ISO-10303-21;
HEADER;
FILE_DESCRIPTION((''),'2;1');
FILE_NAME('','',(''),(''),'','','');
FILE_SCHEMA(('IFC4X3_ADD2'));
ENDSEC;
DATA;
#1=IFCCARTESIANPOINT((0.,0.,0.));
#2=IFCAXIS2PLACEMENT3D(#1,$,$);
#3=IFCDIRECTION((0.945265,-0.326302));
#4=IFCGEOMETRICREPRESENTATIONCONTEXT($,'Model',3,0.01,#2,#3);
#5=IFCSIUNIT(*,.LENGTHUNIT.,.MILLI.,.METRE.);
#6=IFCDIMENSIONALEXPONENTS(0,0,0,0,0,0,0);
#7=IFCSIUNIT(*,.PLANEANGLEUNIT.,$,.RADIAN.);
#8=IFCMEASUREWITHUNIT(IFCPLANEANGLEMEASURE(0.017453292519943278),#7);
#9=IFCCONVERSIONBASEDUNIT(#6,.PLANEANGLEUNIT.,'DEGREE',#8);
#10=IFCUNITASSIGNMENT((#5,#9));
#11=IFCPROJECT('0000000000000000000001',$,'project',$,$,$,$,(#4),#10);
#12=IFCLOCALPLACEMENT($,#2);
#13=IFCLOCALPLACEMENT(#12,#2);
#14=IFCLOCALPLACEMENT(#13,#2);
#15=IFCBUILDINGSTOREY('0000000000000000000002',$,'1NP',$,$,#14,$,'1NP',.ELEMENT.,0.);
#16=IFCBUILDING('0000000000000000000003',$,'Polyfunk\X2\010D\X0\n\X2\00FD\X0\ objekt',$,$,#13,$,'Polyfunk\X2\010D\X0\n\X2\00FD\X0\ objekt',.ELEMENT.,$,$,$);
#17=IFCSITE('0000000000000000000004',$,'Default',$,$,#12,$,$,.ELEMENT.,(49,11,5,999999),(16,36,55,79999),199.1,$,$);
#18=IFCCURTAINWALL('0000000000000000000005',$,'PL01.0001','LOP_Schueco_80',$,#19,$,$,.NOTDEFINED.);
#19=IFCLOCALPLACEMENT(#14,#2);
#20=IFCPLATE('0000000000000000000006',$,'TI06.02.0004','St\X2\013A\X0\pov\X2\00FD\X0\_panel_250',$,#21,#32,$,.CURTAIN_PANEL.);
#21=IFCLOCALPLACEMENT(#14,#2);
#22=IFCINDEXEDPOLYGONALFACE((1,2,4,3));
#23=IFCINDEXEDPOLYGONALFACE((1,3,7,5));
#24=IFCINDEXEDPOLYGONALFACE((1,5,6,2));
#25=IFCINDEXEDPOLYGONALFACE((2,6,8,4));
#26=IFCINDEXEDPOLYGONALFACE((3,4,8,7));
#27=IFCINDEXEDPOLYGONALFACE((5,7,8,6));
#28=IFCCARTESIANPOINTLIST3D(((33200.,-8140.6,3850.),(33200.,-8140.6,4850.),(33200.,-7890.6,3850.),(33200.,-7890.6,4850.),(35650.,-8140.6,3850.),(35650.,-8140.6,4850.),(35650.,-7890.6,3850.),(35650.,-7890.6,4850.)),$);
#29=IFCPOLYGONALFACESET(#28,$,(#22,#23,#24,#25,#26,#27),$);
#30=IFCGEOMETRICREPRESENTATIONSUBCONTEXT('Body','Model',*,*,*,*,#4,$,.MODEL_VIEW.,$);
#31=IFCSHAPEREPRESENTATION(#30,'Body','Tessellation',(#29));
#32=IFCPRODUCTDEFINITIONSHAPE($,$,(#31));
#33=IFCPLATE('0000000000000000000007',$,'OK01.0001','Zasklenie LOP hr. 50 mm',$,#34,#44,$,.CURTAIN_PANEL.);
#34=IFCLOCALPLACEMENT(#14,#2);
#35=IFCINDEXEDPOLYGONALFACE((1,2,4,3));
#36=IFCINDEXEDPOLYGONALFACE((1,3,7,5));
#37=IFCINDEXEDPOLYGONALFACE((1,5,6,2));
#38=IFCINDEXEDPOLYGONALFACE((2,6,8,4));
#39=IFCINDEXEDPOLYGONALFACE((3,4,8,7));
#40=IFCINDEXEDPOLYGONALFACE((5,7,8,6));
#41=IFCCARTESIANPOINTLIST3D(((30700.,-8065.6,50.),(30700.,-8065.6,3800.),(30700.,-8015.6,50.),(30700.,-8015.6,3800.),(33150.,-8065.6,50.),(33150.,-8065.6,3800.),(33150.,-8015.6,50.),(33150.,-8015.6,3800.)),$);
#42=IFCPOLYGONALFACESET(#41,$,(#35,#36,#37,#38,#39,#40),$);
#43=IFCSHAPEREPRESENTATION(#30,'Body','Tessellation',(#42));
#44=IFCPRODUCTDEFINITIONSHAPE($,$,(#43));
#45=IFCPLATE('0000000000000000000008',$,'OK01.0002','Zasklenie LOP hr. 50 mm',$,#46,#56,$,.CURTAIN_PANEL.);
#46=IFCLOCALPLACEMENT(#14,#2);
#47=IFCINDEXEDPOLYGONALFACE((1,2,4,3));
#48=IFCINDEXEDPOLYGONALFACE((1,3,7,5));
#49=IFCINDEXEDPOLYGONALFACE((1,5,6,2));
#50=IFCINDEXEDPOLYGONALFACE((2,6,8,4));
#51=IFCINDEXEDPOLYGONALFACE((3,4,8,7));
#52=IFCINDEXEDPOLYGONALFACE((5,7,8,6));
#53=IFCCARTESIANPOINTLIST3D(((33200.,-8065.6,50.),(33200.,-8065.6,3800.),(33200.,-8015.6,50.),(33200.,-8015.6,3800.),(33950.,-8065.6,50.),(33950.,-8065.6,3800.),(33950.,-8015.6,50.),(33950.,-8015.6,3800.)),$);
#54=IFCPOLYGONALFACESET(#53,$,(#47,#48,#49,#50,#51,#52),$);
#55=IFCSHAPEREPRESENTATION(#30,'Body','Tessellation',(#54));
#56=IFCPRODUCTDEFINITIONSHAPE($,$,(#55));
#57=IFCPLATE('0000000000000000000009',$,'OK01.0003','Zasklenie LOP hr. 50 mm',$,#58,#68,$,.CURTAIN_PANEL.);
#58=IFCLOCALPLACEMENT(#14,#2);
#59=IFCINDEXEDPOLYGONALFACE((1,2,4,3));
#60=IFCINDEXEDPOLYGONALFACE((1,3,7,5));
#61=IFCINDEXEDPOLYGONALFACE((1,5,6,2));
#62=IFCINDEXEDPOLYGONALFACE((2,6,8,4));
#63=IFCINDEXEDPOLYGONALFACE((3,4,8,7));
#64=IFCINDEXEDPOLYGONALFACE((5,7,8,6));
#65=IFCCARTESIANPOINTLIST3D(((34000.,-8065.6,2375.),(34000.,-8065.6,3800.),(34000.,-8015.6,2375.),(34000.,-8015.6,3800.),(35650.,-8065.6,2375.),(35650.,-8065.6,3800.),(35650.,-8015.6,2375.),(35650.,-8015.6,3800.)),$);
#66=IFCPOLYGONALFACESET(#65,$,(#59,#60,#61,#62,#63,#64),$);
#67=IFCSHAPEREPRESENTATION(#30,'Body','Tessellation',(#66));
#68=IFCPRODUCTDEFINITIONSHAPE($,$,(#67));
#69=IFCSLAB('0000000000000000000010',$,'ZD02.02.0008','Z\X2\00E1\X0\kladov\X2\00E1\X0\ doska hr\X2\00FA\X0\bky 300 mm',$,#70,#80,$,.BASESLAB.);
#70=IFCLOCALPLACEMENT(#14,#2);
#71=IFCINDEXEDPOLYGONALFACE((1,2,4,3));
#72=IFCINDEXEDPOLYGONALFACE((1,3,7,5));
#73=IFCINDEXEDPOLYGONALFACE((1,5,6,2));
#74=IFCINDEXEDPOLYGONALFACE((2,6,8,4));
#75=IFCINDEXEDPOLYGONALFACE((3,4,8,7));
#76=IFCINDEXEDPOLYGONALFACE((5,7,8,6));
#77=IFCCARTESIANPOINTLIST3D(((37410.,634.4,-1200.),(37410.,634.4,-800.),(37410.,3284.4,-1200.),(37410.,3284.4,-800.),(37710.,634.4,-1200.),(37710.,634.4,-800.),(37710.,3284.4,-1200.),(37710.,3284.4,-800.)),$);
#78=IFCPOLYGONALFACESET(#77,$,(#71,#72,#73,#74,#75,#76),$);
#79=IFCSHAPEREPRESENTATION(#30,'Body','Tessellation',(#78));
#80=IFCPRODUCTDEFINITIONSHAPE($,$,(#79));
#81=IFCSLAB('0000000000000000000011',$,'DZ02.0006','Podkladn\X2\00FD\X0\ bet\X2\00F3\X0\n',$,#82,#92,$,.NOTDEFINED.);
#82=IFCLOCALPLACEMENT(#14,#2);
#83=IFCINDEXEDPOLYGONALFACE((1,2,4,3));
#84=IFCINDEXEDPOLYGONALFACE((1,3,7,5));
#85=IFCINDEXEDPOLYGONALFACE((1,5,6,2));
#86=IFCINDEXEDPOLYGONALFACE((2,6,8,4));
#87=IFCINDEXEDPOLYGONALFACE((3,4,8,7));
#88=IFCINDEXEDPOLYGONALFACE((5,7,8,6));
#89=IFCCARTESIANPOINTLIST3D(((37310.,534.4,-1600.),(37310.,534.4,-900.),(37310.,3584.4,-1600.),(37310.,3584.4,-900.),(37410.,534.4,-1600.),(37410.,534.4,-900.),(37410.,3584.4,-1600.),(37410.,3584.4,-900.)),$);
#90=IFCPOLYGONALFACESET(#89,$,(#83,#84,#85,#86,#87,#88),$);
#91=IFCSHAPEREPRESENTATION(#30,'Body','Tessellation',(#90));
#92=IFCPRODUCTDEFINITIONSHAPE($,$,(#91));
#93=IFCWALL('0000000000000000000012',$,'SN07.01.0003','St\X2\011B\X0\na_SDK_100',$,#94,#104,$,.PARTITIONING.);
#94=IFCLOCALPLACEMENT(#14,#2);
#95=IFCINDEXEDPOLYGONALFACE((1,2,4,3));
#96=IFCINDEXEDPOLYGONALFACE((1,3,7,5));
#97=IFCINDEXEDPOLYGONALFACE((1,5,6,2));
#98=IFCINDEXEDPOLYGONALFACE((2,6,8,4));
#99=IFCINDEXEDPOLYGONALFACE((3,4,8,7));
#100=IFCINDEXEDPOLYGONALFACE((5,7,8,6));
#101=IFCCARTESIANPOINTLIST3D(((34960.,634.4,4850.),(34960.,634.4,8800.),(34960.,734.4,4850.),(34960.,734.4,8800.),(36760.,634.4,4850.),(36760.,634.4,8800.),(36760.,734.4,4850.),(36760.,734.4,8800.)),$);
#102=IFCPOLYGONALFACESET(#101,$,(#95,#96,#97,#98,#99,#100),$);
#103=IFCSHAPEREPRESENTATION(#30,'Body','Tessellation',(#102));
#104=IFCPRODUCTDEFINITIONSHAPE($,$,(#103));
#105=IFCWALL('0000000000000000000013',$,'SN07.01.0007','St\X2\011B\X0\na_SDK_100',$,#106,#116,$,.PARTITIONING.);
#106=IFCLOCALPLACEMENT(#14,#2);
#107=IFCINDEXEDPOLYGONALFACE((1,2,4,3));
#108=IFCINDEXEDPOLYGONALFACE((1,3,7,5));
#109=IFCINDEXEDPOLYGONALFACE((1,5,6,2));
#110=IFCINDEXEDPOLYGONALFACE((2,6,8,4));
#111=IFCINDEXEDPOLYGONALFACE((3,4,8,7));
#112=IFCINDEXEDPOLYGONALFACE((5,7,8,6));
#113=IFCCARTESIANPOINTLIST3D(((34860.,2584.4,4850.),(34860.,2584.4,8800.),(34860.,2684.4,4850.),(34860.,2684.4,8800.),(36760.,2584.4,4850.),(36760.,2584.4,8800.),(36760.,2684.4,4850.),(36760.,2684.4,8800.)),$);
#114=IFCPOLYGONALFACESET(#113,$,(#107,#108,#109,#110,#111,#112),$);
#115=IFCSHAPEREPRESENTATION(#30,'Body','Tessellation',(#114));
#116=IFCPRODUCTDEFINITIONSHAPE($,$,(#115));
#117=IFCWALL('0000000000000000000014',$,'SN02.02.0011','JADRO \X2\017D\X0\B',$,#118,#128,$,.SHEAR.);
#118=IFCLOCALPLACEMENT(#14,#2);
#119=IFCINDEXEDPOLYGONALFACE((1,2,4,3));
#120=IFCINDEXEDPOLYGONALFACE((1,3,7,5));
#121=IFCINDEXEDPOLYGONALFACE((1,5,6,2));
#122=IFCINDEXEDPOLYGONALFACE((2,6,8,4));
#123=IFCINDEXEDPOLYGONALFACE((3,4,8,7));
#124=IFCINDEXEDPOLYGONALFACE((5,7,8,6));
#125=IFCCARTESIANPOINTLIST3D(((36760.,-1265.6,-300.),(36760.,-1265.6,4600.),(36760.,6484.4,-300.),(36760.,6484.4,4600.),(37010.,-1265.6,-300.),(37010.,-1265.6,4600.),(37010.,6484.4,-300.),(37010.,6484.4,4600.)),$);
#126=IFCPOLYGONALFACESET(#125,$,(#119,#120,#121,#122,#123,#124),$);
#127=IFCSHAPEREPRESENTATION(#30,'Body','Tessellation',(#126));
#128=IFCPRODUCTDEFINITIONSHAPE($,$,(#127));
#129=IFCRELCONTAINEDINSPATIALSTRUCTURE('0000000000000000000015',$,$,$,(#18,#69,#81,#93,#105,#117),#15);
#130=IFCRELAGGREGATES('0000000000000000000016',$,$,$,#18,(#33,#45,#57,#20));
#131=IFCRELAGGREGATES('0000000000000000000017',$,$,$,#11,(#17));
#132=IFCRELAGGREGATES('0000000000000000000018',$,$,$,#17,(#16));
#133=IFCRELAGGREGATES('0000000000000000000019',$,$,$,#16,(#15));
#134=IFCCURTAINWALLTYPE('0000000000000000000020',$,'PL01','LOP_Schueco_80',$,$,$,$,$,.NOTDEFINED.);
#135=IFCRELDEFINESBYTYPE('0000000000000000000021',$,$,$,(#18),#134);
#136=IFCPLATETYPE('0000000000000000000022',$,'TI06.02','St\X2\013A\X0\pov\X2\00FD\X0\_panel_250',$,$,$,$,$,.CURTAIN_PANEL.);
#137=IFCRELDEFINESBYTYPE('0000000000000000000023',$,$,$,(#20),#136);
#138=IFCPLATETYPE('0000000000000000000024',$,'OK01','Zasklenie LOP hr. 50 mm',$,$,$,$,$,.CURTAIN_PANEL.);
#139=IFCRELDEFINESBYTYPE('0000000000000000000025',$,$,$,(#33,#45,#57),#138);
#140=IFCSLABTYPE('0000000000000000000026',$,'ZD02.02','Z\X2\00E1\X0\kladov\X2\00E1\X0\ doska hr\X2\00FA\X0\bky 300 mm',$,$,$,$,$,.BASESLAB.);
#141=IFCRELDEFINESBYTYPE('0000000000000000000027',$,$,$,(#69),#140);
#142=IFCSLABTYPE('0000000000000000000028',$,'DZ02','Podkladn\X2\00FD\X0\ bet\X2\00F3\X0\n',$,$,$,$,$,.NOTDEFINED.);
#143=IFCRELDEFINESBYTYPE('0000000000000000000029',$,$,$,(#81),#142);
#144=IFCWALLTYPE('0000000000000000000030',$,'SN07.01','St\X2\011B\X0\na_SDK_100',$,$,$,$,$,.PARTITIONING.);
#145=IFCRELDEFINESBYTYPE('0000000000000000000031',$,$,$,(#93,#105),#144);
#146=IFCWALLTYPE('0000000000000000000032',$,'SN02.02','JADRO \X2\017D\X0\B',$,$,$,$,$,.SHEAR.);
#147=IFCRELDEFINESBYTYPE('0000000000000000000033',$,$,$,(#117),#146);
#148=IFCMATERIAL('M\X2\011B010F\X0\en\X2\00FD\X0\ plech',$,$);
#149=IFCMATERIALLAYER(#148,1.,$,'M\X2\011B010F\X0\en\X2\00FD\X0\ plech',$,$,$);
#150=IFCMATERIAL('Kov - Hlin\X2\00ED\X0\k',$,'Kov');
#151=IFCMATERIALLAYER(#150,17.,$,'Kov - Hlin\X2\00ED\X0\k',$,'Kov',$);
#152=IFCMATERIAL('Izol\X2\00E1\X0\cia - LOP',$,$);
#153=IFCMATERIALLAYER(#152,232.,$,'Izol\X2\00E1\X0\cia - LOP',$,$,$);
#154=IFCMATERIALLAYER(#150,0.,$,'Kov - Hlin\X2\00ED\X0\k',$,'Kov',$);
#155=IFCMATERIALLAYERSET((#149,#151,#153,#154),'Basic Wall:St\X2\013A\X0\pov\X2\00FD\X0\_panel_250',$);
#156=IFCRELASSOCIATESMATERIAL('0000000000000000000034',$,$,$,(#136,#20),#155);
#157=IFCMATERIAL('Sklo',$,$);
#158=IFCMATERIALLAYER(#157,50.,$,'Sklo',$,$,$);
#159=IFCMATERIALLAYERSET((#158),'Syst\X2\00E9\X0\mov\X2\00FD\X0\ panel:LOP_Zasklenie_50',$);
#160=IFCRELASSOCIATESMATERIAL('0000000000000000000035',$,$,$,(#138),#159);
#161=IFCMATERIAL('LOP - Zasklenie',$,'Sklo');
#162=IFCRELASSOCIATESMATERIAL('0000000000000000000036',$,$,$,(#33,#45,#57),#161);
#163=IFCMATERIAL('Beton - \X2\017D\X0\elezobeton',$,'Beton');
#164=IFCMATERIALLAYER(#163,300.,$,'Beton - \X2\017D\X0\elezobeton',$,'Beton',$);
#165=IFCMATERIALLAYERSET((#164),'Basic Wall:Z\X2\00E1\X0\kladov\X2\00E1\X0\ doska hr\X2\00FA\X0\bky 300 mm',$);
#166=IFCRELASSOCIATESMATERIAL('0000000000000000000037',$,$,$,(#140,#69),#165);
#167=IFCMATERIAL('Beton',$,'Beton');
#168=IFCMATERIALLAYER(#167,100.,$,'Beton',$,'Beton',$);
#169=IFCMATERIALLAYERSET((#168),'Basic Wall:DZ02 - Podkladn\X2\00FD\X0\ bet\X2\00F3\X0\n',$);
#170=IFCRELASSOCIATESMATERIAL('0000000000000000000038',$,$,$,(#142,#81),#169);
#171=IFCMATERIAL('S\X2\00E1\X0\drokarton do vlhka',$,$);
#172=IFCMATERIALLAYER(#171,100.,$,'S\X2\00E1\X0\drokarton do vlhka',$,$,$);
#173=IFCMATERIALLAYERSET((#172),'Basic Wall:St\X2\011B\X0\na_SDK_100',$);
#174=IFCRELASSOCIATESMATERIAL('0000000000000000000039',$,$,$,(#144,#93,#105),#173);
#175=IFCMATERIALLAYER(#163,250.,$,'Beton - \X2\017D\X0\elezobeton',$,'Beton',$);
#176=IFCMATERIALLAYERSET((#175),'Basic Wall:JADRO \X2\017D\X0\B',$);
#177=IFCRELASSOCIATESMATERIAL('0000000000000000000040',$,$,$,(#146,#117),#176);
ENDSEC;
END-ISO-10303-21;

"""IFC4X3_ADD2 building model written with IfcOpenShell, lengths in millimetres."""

from ifc_helpers import new_model, entity, si_unit, converted_unit, direction, frame, frame_2d, origin, place, context, subcontext, project, spatial, polyline, rectangle, extrude, clip, bounded_halfspace, source, transform, mapped, material, layer, layer_set, layer_usage, type_object, type_shapes, element, aggregate, save


model = new_model("IFC4X3_ADD2")

# Units and contexts
model_context = context("Model", 3, precision=0.01, world=origin(), true_north=direction((0.945265, -0.326302)))
body_context = subcontext(model_context, "Body", "Model", "MODEL_VIEW")
ifc_project = project(units=[si_unit("LENGTHUNIT", "METRE", prefix="MILLI"), converted_unit("PLANEANGLEUNIT", "DEGREE", entity("IfcPlaneAngleMeasure", 0.017453292519943278), si_unit("PLANEANGLEUNIT", "RADIAN"), dimensions=[0, 0, 0, 0, 0, 0, 0])], contexts=[model_context])

# Site, building, storey
site_placement = place(None, origin())
site = spatial("IfcSite", under=ifc_project, at=site_placement, Name="Default", CompositionType="ELEMENT", RefLatitude=(49, 11, 5, 999999), RefLongitude=(16, 36, 55, 79999), RefElevation=199.1)
building_placement = place(site_placement, origin())
building = spatial("IfcBuilding", under=site, at=building_placement, Name="Polyfunkčný objekt", LongName="Polyfunkčný objekt", CompositionType="ELEMENT")
storey_placement = place(building_placement, origin())
storey = spatial("IfcBuildingStorey", under=building, at=storey_placement, Name="1NP", LongName="1NP", CompositionType="ELEMENT", Elevation=0.0)

# Curtain wall, plates
curtain_wall_type = type_object("IfcCurtainWallType", Name="PL01", Description="LOP_Schueco_80", PredefinedType="NOTDEFINED")
curtain_wall_placement = place(storey_placement, origin())
curtain_wall = element("IfcCurtainWall", 1, at=curtain_wall_placement, inside=storey, type_object=curtain_wall_type, Name="PL01.0001", Description="LOP_Schueco_80", PredefinedType="NOTDEFINED")
ifc_material_1 = material(Name="Měďený plech")
ifc_layer_1 = layer(ifc_material_1, 1.0, Name="Měďený plech")
ifc_material_2 = material(Name="Kov - Hliník", Category="Kov")
ifc_layer_2 = layer(ifc_material_2, 17.0, Name="Kov - Hliník", Category="Kov")
ifc_material_3 = material(Name="Izolácia - LOP")
ifc_layer_3 = layer(ifc_material_3, 232.0, Name="Izolácia - LOP")
ifc_layer_4 = layer(ifc_material_2, 0.0, Name="Kov - Hliník", Category="Kov")
ifc_layer_set_1 = layer_set([ifc_layer_1, ifc_layer_2, ifc_layer_3, ifc_layer_4], Name="Basic Wall:Stĺpový_panel_250")
ifc_layer_usage_1 = layer_usage(ifc_layer_set_1, "AXIS2", "POSITIVE", -125.0)
plate_type_1 = type_object("IfcPlateType", Name="TI06.02", Description="Stĺpový_panel_250", PredefinedType="CURTAIN_PANEL", material=ifc_layer_set_1)
plate_1_placement = place(storey_placement, frame((33200.0, -8015.6, 3850.0)))
plate_1 = element("IfcPlate", 2, at=plate_1_placement, type_object=plate_type_1, material=ifc_layer_usage_1, Name="TI06.02.0004", Description="Stĺpový_panel_250", PredefinedType="CURTAIN_PANEL", context=body_context, shape_type="SweptSolid", body=[
    extrude(rectangle(XDim=250.0, YDim=2450.0, at=frame_2d((0.0, 0.0), x_axis=(1.0, 0.0))), frame((1225.0, 0.0, 0.0), z_axis=(0.0, 0.0, 1.0), x_axis=(0.0, 1.0, 0.0)), (0.0, 0.0, 1.0), 1000.0),
])
ifc_material_4 = material(Name="LOP - Zasklenie", Category="Sklo")
ifc_material_5 = material(Name="Sklo")
ifc_layer_5 = layer(ifc_material_5, 50.0, Name="Sklo")
ifc_layer_set_2 = layer_set([ifc_layer_5], Name="Systémový panel:LOP_Zasklenie_50")
plate_type_2 = type_object("IfcPlateType", Name="OK01", Description="Zasklenie LOP hr. 50 mm", PredefinedType="CURTAIN_PANEL", material=ifc_layer_set_2)
shared_shape_1 = source(origin(), body_context, "Body", "SweptSolid", [
    extrude(rectangle(XDim=3750.0, YDim=2450.0, at=frame_2d((-331.2, 0.0), x_axis=(1.0, 0.0))), frame((0.0, -50.0, 2206.2), z_axis=(0.0, 1.0, 0.0), x_axis=(0.0, 0.0, 1.0)), (0.0, 0.0, 1.0), 50.0),
])
plate_2_placement = place(curtain_wall_placement, frame((31925.0, -8015.6, 50.0)))
plate_2 = element("IfcPlate", 3, at=plate_2_placement, type_object=plate_type_2, material=ifc_material_4, Name="OK01.0001", Description="Zasklenie LOP hr. 50 mm", PredefinedType="CURTAIN_PANEL", context=body_context, shape_type="MappedRepresentation", body=[
    mapped(shared_shape_1, transform((0.0, 0.0, 0.0), scale=1.0)),
])
shared_shape_2 = source(origin(), body_context, "Body", "SweptSolid", [
    extrude(rectangle(XDim=3750.0, YDim=750.0, at=frame_2d((-331.2, 0.0), x_axis=(1.0, 0.0))), frame((0.0, -50.0, 2206.2), z_axis=(0.0, 1.0, 0.0), x_axis=(0.0, 0.0, 1.0)), (0.0, 0.0, 1.0), 50.0),
])
plate_3_placement = place(curtain_wall_placement, frame((33575.0, -8015.6, 50.0)))
plate_3 = element("IfcPlate", 4, at=plate_3_placement, type_object=plate_type_2, material=ifc_material_4, Name="OK01.0002", Description="Zasklenie LOP hr. 50 mm", PredefinedType="CURTAIN_PANEL", context=body_context, shape_type="MappedRepresentation", body=[
    mapped(shared_shape_2, transform((0.0, 0.0, 0.0), scale=1.0)),
])
shared_shape_3 = source(origin(), body_context, "Body", "SweptSolid", [
    extrude(rectangle(XDim=1425.0, YDim=1650.0, at=frame_2d((87.6, 0.0), x_axis=(1.0, 0.0))), frame((0.0, -50.0, 624.9), z_axis=(0.0, 1.0, 0.0), x_axis=(0.0, 0.0, 1.0)), (0.0, 0.0, 1.0), 50.0),
])
type_shapes(plate_type_2, [shared_shape_1, shared_shape_2, shared_shape_3])
plate_4_placement = place(curtain_wall_placement, frame((34825.0, -8015.6, 2375.0)))
plate_4 = element("IfcPlate", 5, at=plate_4_placement, type_object=plate_type_2, material=ifc_material_4, Name="OK01.0003", Description="Zasklenie LOP hr. 50 mm", PredefinedType="CURTAIN_PANEL", context=body_context, shape_type="MappedRepresentation", body=[
    mapped(shared_shape_3, transform((0.0, 0.0, 0.0), scale=1.0)),
])
aggregate(curtain_wall, [plate_2, plate_3, plate_4, plate_1])

# Slabs
ifc_material_6 = material(Name="Beton - Železobeton", Category="Beton")
ifc_layer_6 = layer(ifc_material_6, 300.0, Name="Beton - Železobeton", Category="Beton")
ifc_layer_set_3 = layer_set([ifc_layer_6], Name="Basic Wall:Základová doska hrúbky 300 mm")
slab_type_1 = type_object("IfcSlabType", Name="ZD02.02", Description="Základová doska hrúbky 300 mm", PredefinedType="BASESLAB", material=ifc_layer_set_3)
slab_1_placement = place(storey_placement, frame((37560.0, 634.4, -1200.0), z_axis=(0.0, 0.0, 1.0), x_axis=(0.0, 1.0, 0.0)))
element("IfcSlab", 6, at=slab_1_placement, inside=storey, type_object=slab_type_1, material=ifc_layer_set_3, Name="ZD02.02.0008", Description="Základová doska hrúbky 300 mm", PredefinedType="BASESLAB", context=body_context, shape_type="SweptSolid", body=[
    extrude(rectangle(XDim=2650.0, YDim=300.0, at=frame_2d((1325.0, 0.0), x_axis=(-1.0, 0.0))), origin(), (0.0, 0.0, 1.0), 400.0),
])
ifc_material_7 = material(Name="Beton", Category="Beton")
ifc_layer_7 = layer(ifc_material_7, 100.0, Name="Beton", Category="Beton")
ifc_layer_set_4 = layer_set([ifc_layer_7], Name="Basic Wall:DZ02 - Podkladný betón")
slab_type_2 = type_object("IfcSlabType", Name="DZ02", Description="Podkladný betón", PredefinedType="NOTDEFINED", material=ifc_layer_set_4)
slab_2_placement = place(storey_placement, frame((37360.0, 534.4, -1600.0), z_axis=(0.0, 0.0, 1.0), x_axis=(0.0, 1.0, 0.0)))
element("IfcSlab", 7, at=slab_2_placement, inside=storey, type_object=slab_type_2, material=ifc_layer_set_4, Name="DZ02.0006", Description="Podkladný betón", PredefinedType="NOTDEFINED", context=body_context, shape_type="SweptSolid", body=[
    extrude(rectangle(XDim=3050.0, YDim=100.0, at=frame_2d((1525.0, 0.0), x_axis=(-1.0, 0.0))), origin(), (0.0, 0.0, 1.0), 700.0),
])

# Walls
ifc_material_8 = material(Name="Sádrokarton do vlhka")
ifc_layer_8 = layer(ifc_material_8, 100.0, Name="Sádrokarton do vlhka")
ifc_layer_set_5 = layer_set([ifc_layer_8], Name="Basic Wall:Stěna_SDK_100")
wall_type_1 = type_object("IfcWallType", Name="SN07.01", Description="Stěna_SDK_100", PredefinedType="PARTITIONING", material=ifc_layer_set_5)
wall_1_placement = place(storey_placement, frame((34960.0, 684.4, 4850.0)))
element("IfcWall", 8, at=wall_1_placement, inside=storey, type_object=wall_type_1, material=ifc_layer_set_5, Name="SN07.01.0003", Description="Stěna_SDK_100", PredefinedType="PARTITIONING", context=body_context, shape_type="Clipping", body=[
    clip(clip(extrude(rectangle(XDim=1800.0, YDim=100.0, at=frame_2d((900.0, 0.0), x_axis=(-1.0, 0.0))), origin(), (0.0, 0.0, 1.0), 3950.0), bounded_halfspace(frame((1800.0, -50.0, 0.0), z_axis=(0.0, 0.0, 1.0), x_axis=(-1.0, 0.0, 0.0)), True, frame((1800.0, -50.0, 0.0)), polyline([(0.0, 0.0), (0.0, 100.0), (-1800.0, 100.0), (-1800.0, 0.0), (0.0, 0.0)]))), bounded_halfspace(frame((0.0, -50.0, 3950.0), z_axis=(0.0, 0.0, -1.0), x_axis=(1.0, 0.0, 0.0)), True, frame((0.0, -50.0, 3950.0)), polyline([(0.0, 0.0), (1800.0, 0.0), (1800.0, 100.0), (0.0, 100.0), (0.0, 0.0)]))),
])
wall_2_placement = place(storey_placement, frame((34860.0, 2634.4, 4850.0)))
element("IfcWall", 9, at=wall_2_placement, inside=storey, type_object=wall_type_1, material=ifc_layer_set_5, Name="SN07.01.0007", Description="Stěna_SDK_100", PredefinedType="PARTITIONING", context=body_context, shape_type="Clipping", body=[
    clip(clip(extrude(rectangle(XDim=1900.0, YDim=100.0, at=frame_2d((950.0, 0.0), x_axis=(-1.0, 0.0))), origin(), (0.0, 0.0, 1.0), 3950.0), bounded_halfspace(frame((1900.0, -50.0, 0.0), z_axis=(0.0, 0.0, 1.0), x_axis=(-1.0, 0.0, 0.0)), True, frame((1900.0, -50.0, 0.0)), polyline([(0.0, 0.0), (0.0, 100.0), (-150.0, 100.0), (-1900.0, 100.0), (-1900.0, 0.0), (-1800.0, 0.0), (0.0, 0.0)]))), bounded_halfspace(frame((0.0, -50.0, 3950.0), z_axis=(0.0, 0.0, -1.0), x_axis=(1.0, 0.0, 0.0)), True, frame((0.0, -50.0, 3950.0)), polyline([(0.0, 0.0), (100.0, 0.0), (1900.0, 0.0), (1900.0, 100.0), (1750.0, 100.0), (0.0, 100.0), (0.0, 0.0)]))),
])
ifc_layer_9 = layer(ifc_material_6, 250.0, Name="Beton - Železobeton", Category="Beton")
ifc_layer_set_6 = layer_set([ifc_layer_9], Name="Basic Wall:JADRO ŽB")
wall_type_2 = type_object("IfcWallType", Name="SN02.02", Description="JADRO ŽB", PredefinedType="SHEAR", material=ifc_layer_set_6)
wall_3_placement = place(storey_placement, frame((36885.0, -1265.6, -300.0), z_axis=(0.0, 0.0, 1.0), x_axis=(0.0, 1.0, 0.0)))
element("IfcWall", 10, at=wall_3_placement, inside=storey, type_object=wall_type_2, material=ifc_layer_set_6, Name="SN02.02.0011", Description="JADRO ŽB", PredefinedType="SHEAR", context=body_context, shape_type="Clipping", body=[
    clip(clip(extrude(rectangle(XDim=7750.0, YDim=250.0, at=frame_2d((3875.0, 0.0), x_axis=(-1.0, 0.0))), origin(), (0.0, 0.0, 1.0), 4900.0), bounded_halfspace(frame((7750.0, 125.0, 4900.0), z_axis=(0.0, 0.0, -1.0), x_axis=(0.0, -1.0, 0.0)), True, frame((7750.0, 125.0, 4900.0)), polyline([(0.0, 0.0), (-7750.0, 0.0), (-7750.0, -250.0), (-7500.0, -250.0), (-5800.0, -250.0), (-5550.0, -250.0), (-3200.0, -250.0), (-2950.0, -250.0), (-250.0, -250.0), (0.0, -250.0), (0.0, 0.0)]))), bounded_halfspace(frame((7750.0, -125.0, 0.0)), True, frame((7750.0, -125.0, 0.0)), polyline([(0.0, 0.0), (0.0, 250.0), (-390.0, 250.0), (-7750.0, 250.0), (-7750.0, 0.0), (-7500.0, 0.0), (-5800.0, 0.0), (-5550.0, 0.0), (-3200.0, 0.0), (-2950.0, 0.0), (-250.0, 0.0), (0.0, 0.0)]))),
])

save(model, "model.ifc")
